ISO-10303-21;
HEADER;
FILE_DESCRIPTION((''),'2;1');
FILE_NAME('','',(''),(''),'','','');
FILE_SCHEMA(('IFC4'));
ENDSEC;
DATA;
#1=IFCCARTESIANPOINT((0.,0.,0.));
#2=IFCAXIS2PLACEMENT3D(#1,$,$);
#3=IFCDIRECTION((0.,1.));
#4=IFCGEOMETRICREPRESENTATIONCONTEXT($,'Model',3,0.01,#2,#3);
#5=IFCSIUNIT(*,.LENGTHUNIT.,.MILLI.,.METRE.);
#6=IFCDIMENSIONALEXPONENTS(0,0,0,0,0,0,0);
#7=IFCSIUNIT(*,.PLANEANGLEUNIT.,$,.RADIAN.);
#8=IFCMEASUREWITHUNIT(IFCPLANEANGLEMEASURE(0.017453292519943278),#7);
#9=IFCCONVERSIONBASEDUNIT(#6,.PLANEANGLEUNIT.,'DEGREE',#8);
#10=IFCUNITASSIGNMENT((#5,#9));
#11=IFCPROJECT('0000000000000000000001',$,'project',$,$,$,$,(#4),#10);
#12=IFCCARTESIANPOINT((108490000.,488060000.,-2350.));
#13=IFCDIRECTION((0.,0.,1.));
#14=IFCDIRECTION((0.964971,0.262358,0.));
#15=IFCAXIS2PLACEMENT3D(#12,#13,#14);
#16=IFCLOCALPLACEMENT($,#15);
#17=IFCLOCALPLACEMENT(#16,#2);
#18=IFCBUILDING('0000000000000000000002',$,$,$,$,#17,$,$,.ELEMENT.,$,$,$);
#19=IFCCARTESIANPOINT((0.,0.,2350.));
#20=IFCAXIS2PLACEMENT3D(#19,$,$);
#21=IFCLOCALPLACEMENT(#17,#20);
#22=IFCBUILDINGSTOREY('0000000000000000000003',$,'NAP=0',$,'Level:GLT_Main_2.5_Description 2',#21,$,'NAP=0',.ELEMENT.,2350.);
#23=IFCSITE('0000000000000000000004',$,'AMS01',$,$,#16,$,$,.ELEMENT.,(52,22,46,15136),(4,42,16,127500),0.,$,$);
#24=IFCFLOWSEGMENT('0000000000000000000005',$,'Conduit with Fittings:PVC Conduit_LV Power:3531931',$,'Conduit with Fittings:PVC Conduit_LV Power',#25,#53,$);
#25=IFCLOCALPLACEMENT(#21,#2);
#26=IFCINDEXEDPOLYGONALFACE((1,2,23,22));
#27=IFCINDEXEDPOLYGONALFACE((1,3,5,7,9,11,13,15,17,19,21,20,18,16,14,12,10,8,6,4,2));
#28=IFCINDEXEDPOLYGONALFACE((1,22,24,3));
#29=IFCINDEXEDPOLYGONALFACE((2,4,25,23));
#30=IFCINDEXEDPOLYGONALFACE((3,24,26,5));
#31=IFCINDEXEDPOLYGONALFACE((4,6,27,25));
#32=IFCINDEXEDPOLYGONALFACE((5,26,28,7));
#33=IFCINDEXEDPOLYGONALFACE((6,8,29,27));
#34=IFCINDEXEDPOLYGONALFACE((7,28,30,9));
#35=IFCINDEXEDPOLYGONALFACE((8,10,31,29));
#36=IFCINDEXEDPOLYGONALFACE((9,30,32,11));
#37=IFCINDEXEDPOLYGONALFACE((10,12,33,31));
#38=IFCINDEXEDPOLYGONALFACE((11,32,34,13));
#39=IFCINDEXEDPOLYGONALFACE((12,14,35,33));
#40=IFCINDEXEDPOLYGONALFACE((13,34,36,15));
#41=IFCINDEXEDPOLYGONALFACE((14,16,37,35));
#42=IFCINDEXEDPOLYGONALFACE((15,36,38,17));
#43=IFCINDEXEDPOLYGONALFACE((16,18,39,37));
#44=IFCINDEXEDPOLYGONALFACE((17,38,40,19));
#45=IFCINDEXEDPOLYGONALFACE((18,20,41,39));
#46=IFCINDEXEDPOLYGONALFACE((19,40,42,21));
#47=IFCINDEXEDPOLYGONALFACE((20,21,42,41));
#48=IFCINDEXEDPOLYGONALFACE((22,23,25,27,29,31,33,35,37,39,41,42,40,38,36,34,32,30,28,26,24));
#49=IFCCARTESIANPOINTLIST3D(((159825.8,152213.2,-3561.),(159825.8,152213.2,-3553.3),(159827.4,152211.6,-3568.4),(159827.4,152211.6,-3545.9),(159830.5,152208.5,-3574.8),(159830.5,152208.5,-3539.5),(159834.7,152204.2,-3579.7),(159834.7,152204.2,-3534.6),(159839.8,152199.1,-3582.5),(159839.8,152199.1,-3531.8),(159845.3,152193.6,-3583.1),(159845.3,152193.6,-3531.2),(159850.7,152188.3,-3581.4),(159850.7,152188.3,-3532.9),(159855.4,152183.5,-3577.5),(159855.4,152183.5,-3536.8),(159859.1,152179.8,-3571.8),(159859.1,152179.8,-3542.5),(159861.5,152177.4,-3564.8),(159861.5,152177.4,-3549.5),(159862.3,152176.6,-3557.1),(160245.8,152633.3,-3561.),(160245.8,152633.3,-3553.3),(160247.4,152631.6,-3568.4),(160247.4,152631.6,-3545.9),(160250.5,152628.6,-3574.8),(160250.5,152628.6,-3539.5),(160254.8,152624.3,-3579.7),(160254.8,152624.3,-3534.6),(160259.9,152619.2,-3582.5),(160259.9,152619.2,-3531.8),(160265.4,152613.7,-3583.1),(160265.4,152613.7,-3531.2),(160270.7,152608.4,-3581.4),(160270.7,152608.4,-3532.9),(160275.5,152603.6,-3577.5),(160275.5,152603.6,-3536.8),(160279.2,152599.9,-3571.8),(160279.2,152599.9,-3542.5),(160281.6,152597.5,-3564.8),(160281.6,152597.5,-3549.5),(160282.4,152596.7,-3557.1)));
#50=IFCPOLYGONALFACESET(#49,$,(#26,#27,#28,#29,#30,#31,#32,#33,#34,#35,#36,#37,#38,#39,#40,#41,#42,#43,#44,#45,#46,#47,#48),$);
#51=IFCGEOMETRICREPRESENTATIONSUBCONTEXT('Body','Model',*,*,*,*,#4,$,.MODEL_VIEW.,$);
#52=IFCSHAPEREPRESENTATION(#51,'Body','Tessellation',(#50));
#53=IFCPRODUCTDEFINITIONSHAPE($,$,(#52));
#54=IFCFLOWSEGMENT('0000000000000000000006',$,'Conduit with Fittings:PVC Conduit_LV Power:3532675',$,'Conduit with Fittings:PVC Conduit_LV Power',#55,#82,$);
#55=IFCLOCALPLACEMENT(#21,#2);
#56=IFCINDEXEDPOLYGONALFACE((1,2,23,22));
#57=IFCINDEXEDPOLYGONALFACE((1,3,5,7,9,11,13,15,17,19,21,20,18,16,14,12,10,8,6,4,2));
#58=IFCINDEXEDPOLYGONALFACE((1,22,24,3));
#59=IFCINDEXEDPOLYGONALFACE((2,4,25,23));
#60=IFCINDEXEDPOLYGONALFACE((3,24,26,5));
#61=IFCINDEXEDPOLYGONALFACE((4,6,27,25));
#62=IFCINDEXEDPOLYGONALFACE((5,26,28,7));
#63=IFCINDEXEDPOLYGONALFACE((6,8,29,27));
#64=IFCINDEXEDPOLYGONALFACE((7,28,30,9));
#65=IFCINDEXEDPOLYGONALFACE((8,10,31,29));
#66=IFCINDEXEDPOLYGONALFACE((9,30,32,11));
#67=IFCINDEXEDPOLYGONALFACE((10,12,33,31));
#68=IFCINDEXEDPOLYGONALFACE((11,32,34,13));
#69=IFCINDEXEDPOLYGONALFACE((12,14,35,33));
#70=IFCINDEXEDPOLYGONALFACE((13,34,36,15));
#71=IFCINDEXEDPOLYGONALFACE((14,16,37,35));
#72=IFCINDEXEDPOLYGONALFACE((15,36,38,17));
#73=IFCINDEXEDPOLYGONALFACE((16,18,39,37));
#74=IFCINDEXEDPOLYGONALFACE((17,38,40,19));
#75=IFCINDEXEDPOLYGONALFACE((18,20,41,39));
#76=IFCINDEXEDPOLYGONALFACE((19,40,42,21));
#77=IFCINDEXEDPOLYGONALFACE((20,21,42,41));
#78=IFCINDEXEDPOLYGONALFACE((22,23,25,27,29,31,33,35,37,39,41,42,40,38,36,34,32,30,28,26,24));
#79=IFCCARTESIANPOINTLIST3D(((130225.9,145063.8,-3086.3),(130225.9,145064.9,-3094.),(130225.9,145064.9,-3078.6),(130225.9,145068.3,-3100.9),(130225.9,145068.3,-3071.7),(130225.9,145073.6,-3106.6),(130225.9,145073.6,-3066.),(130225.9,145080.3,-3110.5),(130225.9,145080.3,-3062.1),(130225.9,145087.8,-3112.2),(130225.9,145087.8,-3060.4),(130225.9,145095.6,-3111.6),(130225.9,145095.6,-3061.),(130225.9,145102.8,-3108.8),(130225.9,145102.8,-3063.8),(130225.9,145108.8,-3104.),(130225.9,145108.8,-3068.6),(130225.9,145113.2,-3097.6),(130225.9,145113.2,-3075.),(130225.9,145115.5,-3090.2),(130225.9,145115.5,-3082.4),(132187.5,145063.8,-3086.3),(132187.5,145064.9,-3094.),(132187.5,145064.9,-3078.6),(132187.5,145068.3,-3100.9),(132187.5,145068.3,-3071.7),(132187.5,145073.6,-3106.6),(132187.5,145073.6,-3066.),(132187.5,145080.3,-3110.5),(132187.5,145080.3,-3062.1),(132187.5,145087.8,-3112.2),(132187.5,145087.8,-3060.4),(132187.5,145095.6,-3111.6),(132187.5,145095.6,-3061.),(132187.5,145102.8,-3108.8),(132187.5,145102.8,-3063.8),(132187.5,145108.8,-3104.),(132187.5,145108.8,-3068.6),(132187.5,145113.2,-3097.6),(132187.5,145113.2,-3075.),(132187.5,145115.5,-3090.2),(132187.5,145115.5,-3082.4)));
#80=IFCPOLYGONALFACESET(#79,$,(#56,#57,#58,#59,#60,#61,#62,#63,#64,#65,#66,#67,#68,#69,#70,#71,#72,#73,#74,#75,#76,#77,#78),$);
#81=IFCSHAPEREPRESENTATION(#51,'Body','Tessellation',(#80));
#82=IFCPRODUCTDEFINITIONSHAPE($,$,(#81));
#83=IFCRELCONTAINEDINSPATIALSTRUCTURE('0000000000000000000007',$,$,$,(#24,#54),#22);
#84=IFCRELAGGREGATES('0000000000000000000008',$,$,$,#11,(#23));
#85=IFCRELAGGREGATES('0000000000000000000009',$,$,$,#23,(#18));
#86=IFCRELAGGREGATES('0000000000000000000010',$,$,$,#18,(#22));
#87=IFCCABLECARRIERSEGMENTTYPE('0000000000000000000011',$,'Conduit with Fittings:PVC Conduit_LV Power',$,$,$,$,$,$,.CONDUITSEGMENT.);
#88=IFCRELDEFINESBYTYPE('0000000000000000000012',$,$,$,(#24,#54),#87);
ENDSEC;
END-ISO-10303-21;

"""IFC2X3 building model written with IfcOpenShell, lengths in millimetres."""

from ifc_helpers import new_model, entity, si_unit, converted_unit, direction, frame, origin, origin_2d_with_axis, place, context, subcontext, project, spatial, circle, extrude, type_object, element, save


model = new_model("IFC2X3")

# Units and contexts
model_context = context("Model", 3, precision=0.01, world=origin(), true_north=direction((0.0, 1.0)))
body_context = subcontext(model_context, "Body", "Model", "MODEL_VIEW")
ifc_project = project(units=[si_unit("LENGTHUNIT", "METRE", prefix="MILLI"), converted_unit("PLANEANGLEUNIT", "DEGREE", entity("IfcPlaneAngleMeasure", 0.017453292519943278), si_unit("PLANEANGLEUNIT", "RADIAN"), dimensions=[0, 0, 0, 0, 0, 0, 0])], contexts=[model_context])

# Site, building, storey
site_placement = place(None, frame((108490000.0, 488060000.0, -2350.0), z_axis=(0.0, 0.0, 1.0), x_axis=(0.964971, 0.262358, 0.0)))
site = spatial("IfcSite", under=ifc_project, at=site_placement, Name="AMS01", CompositionType="ELEMENT", RefLatitude=(52, 22, 46, 15136), RefLongitude=(4, 42, 16, 127500), RefElevation=0.0)
building_placement = place(site_placement, origin())
building = spatial("IfcBuilding", under=site, at=building_placement, CompositionType="ELEMENT")
storey_placement = place(building_placement, frame((0.0, 0.0, 2350.0)))
storey = spatial("IfcBuildingStorey", under=building, at=storey_placement, Name="NAP=0", ObjectType="Level:GLT_Main_2.5_Description 2", LongName="NAP=0", CompositionType="ELEMENT", Elevation=2350.0)

# Flow segments
cable_carrier_segment_type = type_object("IfcCableCarrierSegmentType", Name="Conduit with Fittings:PVC Conduit_LV Power", PredefinedType="CONDUITSEGMENT")
flow_segment_1_placement = place(storey_placement, origin())
element("IfcFlowSegment", 1, at=flow_segment_1_placement, inside=storey, type_object=cable_carrier_segment_type, Name="Conduit with Fittings:PVC Conduit_LV Power:3531931", ObjectType="Conduit with Fittings:PVC Conduit_LV Power", context=body_context, shape_type="SweptSolid", body=[
    extrude(circle(Radius=26.0, at=origin_2d_with_axis()), frame((159843.9, 152195.0, -3557.1), z_axis=(0.707111, 0.707102, 0.0), x_axis=(0.707102, -0.707111, 0.0)), (0.0, 0.0, 1.0), 594.1),
])
flow_segment_2_placement = place(storey_placement, origin())
element("IfcFlowSegment", 2, at=flow_segment_2_placement, inside=storey, type_object=cable_carrier_segment_type, Name="Conduit with Fittings:PVC Conduit_LV Power:3532675", ObjectType="Conduit with Fittings:PVC Conduit_LV Power", context=body_context, shape_type="SweptSolid", body=[
    extrude(circle(Radius=26.0, at=origin_2d_with_axis()), frame((130225.9, 145089.8, -3086.3), z_axis=(1.0, 0.0, 0.0), x_axis=(0.0, -1.0, 0.0)), (0.0, 0.0, 1.0), 1961.6),
])

save(model, "model.ifc")
